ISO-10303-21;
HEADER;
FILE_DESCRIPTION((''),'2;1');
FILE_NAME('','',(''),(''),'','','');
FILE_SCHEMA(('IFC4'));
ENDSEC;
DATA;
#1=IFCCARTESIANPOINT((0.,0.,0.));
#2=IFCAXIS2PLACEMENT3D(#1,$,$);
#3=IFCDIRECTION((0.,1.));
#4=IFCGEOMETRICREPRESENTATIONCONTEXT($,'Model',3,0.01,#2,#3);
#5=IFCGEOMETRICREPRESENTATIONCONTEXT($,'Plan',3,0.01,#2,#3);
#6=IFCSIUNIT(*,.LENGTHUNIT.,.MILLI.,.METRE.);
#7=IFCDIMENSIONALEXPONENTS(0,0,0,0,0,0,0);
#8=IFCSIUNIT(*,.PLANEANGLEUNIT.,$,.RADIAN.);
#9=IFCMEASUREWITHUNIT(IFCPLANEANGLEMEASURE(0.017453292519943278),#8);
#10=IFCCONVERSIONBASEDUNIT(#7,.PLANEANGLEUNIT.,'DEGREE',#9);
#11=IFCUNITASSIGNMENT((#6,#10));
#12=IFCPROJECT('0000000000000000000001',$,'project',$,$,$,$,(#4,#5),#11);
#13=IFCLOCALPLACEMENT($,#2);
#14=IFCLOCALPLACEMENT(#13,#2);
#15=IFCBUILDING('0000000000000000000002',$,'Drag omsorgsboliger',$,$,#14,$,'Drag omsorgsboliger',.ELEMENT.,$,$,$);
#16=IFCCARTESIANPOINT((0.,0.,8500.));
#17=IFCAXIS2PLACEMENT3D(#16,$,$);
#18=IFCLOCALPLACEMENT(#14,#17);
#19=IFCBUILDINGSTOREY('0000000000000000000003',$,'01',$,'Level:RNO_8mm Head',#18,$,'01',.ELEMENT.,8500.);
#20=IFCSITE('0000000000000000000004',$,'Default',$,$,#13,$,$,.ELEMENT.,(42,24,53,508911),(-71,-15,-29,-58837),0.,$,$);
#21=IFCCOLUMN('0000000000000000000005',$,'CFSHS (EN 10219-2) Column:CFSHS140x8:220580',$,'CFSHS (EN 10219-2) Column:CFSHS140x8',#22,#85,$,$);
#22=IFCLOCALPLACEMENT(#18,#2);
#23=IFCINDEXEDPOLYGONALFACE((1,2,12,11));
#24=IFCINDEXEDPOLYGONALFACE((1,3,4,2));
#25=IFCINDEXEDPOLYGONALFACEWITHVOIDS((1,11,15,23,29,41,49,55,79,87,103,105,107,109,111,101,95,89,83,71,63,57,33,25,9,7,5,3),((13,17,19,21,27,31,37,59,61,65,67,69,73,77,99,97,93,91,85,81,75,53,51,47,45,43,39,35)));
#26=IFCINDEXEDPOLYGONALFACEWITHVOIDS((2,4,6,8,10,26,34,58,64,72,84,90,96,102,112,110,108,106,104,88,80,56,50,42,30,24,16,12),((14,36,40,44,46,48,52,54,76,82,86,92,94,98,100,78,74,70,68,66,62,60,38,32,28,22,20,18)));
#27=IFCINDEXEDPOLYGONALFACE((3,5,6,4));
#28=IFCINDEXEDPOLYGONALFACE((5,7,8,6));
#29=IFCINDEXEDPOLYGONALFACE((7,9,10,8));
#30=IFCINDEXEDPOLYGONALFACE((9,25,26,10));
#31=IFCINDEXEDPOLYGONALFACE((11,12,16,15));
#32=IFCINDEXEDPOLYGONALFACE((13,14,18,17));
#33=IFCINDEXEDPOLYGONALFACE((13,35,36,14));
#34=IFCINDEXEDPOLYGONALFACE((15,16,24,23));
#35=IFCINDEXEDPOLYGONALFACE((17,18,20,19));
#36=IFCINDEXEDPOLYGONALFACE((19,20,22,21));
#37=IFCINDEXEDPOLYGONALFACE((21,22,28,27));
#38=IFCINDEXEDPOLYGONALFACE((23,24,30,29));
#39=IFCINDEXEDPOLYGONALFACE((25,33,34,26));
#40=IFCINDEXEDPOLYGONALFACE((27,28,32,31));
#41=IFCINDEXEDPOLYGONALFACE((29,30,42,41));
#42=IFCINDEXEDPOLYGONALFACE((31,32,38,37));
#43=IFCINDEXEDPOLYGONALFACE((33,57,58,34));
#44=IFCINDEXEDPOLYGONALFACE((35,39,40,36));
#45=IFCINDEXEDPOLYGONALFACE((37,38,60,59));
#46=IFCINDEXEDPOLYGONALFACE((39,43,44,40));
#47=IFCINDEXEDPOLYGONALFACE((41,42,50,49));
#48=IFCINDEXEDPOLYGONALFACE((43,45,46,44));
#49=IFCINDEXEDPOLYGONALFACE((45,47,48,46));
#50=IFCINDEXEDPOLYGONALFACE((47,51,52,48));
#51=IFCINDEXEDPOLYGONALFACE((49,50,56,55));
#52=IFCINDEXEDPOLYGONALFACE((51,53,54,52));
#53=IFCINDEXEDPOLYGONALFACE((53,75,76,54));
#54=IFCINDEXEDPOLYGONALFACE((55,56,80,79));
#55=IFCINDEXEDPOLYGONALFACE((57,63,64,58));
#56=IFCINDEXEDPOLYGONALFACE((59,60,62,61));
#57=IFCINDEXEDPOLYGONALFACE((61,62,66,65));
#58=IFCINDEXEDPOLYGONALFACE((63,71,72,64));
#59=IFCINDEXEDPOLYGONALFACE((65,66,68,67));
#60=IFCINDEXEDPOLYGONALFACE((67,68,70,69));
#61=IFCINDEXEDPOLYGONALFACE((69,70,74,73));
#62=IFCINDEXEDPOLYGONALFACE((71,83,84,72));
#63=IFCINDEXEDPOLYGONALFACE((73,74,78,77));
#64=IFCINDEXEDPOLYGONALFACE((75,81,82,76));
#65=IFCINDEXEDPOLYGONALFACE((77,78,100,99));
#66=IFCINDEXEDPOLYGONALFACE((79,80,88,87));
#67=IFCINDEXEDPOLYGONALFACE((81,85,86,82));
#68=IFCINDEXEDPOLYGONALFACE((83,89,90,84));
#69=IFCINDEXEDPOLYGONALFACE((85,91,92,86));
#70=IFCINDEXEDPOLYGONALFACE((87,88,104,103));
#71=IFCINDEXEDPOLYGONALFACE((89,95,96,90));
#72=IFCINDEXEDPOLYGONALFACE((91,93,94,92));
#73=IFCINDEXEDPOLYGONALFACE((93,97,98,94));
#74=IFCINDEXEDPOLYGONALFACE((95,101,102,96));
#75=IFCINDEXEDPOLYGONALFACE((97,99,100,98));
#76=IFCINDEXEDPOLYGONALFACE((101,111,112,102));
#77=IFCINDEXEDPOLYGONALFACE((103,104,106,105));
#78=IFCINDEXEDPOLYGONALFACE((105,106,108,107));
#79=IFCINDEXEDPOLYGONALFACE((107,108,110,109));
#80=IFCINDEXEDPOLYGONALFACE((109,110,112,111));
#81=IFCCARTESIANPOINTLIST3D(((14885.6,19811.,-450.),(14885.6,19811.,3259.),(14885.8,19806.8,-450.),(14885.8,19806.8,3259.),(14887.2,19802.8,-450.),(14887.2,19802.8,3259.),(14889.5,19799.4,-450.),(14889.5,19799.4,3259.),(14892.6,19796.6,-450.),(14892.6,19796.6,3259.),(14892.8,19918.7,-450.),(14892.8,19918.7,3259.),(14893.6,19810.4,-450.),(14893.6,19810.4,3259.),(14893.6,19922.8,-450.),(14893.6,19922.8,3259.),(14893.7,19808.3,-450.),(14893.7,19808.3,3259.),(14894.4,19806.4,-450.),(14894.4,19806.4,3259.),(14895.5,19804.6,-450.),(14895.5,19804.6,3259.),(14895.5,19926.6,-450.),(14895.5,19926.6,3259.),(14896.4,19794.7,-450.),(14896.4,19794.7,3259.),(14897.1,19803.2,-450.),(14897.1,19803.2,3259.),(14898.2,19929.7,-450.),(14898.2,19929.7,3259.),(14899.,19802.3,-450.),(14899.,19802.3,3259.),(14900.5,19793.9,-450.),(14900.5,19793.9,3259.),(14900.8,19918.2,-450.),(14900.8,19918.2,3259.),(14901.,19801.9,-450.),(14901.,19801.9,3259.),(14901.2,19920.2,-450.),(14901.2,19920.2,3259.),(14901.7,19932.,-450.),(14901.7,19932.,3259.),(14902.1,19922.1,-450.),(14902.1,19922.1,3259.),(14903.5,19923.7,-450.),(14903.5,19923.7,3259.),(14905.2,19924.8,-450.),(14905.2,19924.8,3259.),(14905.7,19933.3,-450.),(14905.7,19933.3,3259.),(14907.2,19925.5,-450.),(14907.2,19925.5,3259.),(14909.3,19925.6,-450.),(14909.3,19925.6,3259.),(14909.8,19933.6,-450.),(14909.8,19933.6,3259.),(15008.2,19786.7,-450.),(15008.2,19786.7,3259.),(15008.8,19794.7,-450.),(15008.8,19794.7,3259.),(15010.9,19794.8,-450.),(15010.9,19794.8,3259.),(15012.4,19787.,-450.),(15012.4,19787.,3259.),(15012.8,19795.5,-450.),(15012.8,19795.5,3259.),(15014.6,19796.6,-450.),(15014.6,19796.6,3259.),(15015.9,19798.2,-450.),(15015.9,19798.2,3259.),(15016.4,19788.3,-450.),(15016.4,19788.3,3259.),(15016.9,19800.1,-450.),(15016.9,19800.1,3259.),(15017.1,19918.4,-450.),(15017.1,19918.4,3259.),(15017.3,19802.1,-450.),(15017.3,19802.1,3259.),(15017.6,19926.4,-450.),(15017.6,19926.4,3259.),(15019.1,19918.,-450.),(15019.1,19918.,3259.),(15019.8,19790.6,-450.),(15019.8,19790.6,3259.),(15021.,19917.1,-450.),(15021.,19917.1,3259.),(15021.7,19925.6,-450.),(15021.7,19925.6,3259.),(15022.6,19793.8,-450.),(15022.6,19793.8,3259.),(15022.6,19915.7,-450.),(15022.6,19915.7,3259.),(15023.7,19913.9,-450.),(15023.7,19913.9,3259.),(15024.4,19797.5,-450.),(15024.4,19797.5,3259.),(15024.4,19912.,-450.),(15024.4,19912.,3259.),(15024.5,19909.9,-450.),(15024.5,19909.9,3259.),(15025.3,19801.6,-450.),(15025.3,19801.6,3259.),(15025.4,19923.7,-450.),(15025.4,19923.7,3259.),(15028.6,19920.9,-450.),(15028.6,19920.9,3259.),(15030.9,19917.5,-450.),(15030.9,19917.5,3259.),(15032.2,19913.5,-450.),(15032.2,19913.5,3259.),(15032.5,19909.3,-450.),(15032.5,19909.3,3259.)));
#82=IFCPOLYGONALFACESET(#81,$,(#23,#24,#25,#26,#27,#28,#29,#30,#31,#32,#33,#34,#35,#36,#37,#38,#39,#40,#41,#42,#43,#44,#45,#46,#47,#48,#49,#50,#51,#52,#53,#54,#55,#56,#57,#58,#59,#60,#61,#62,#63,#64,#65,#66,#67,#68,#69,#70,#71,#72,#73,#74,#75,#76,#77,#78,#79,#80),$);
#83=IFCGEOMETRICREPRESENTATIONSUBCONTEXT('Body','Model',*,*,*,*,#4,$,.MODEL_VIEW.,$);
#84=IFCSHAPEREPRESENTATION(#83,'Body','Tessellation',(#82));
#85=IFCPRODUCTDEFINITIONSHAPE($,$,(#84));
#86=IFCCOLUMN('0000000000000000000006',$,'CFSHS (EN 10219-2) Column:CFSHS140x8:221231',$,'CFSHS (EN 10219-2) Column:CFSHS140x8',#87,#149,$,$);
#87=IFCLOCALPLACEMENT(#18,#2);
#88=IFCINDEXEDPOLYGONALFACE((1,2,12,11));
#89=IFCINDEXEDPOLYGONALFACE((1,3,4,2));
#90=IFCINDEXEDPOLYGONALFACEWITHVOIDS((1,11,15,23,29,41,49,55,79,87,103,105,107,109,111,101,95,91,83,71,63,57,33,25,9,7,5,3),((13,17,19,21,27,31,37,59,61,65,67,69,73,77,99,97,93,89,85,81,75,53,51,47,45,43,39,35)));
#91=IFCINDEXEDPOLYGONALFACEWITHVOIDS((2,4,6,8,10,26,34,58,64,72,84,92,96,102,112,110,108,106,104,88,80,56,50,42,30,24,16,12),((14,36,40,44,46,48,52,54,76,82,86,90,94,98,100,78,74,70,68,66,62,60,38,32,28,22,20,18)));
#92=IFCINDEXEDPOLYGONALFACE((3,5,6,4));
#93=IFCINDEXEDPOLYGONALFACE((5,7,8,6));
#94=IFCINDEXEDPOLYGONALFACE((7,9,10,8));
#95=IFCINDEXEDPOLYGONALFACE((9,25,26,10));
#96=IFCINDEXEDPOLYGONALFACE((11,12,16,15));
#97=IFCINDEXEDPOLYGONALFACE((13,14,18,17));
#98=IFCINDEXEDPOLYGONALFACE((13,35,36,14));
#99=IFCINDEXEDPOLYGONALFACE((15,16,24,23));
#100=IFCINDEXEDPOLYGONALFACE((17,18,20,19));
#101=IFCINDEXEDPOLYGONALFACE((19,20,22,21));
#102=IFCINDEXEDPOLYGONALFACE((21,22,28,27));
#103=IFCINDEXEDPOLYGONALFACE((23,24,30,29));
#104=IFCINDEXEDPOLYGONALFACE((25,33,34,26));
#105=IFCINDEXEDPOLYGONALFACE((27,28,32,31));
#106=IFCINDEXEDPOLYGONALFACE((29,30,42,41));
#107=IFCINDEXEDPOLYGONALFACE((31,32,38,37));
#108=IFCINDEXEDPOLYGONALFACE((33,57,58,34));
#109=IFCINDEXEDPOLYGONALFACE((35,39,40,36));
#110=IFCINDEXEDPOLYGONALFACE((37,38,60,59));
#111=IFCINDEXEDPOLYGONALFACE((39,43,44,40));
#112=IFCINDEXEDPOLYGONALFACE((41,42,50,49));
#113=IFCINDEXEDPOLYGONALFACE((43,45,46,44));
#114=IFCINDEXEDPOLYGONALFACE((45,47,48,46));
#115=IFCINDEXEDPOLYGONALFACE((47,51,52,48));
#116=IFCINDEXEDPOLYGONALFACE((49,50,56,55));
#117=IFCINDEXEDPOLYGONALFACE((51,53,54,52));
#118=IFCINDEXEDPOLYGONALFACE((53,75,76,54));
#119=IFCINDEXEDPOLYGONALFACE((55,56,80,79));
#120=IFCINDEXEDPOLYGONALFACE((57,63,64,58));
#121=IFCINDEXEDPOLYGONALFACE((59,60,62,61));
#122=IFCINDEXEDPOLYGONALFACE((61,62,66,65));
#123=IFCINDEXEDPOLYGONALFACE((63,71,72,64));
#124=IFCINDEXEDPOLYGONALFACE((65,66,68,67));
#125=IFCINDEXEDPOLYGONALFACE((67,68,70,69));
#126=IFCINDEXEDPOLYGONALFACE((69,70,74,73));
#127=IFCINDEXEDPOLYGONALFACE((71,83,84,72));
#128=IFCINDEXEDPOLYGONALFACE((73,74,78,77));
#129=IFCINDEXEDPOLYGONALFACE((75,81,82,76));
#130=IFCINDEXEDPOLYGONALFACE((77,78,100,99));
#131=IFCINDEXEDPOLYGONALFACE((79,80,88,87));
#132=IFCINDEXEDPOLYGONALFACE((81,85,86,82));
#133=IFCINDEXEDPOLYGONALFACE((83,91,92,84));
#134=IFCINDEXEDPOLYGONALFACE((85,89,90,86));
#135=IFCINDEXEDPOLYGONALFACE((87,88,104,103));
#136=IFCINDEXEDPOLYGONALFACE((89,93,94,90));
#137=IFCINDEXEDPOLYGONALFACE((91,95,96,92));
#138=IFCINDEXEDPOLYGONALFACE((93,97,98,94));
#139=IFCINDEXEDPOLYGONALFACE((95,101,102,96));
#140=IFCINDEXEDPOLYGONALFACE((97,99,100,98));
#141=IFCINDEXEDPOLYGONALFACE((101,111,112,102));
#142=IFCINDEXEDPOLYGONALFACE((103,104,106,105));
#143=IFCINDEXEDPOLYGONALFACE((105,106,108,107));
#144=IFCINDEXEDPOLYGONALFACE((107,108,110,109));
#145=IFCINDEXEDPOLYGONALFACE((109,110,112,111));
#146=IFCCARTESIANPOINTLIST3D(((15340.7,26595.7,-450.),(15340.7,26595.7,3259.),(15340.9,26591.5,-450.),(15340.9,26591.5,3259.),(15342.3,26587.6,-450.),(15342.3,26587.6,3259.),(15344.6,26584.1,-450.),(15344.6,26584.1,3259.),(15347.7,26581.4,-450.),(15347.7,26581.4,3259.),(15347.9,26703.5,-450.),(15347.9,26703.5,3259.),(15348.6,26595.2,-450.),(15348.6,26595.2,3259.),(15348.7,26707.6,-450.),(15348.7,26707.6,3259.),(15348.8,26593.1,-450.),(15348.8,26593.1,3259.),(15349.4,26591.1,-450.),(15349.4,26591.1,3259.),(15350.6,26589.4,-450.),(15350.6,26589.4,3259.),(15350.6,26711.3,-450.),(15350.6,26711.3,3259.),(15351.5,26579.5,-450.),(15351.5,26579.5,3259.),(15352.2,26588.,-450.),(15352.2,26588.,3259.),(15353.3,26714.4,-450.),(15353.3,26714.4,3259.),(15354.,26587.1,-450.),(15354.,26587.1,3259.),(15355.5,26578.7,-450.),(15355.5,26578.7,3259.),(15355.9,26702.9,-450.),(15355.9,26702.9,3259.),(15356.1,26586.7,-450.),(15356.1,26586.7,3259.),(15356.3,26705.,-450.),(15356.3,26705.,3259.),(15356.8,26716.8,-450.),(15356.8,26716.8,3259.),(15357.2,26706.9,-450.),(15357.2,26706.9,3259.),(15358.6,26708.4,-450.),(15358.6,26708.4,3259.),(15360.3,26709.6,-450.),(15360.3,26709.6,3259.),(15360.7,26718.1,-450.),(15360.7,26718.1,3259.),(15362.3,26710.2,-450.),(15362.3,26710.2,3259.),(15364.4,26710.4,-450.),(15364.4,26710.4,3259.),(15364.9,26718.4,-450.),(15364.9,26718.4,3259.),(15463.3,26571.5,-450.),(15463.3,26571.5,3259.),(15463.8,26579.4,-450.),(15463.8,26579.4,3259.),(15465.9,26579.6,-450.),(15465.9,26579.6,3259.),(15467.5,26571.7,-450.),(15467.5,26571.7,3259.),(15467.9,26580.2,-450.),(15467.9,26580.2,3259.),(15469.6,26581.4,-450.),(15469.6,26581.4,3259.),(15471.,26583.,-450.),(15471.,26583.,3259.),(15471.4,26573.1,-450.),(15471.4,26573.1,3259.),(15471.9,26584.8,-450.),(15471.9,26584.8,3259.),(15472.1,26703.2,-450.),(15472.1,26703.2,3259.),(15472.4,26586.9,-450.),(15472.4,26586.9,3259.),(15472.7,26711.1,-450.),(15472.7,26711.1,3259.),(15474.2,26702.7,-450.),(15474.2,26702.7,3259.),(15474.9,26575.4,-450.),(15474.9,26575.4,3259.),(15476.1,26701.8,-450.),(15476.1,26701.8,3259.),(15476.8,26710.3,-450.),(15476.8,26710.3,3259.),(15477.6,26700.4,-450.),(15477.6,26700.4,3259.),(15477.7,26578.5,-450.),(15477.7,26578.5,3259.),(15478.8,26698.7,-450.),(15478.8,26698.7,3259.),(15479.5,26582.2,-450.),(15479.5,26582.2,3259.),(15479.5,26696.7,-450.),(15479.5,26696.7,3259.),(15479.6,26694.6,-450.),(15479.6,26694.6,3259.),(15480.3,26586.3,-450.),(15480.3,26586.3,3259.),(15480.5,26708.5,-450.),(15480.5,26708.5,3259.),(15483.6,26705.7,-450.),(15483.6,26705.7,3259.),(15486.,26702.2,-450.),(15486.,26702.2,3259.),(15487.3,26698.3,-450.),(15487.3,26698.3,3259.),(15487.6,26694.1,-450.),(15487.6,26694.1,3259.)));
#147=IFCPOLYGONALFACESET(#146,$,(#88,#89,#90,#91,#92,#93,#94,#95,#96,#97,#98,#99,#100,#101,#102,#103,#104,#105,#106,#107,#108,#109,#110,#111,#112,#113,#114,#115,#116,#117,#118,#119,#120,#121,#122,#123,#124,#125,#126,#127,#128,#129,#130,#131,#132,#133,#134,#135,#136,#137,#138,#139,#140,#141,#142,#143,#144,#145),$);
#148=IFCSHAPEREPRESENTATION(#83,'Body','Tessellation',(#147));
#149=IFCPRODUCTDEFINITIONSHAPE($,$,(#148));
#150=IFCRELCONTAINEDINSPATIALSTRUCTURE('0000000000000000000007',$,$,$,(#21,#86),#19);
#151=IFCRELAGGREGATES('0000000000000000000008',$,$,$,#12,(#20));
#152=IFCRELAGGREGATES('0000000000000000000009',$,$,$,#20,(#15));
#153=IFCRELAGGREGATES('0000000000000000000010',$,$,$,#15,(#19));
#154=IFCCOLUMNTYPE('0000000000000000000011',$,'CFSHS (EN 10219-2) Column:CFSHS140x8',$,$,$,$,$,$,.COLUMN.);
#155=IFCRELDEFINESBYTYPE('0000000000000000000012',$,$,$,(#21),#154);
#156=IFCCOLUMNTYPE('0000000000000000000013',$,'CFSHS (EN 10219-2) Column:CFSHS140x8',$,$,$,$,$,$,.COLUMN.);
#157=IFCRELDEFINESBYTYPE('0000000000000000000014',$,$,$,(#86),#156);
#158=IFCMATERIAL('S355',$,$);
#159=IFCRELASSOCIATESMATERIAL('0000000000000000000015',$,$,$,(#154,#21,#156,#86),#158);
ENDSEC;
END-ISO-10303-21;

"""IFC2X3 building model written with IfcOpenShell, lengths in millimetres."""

from ifc_helpers import new_model, entity, si_unit, converted_unit, direction, frame, frame_2d, origin, place, context, subcontext, project, spatial, polyline, circle_curve, parameter, trimmed, segment, composite_curve, outline, extrude, source, transform, mapped, material, type_object, type_shapes, element, save


model = new_model("IFC2X3")

# Units and contexts
model_context = context("Model", 3, precision=0.01, world=origin(), true_north=direction((0.0, 1.0)))
plan_context = context("Plan", 3, precision=0.01, world=origin(), true_north=direction((0.0, 1.0)))
body_context = subcontext(model_context, "Body", "Model", "MODEL_VIEW")
ifc_project = project(units=[si_unit("LENGTHUNIT", "METRE", prefix="MILLI"), converted_unit("PLANEANGLEUNIT", "DEGREE", entity("IfcPlaneAngleMeasure", 0.017453292519943278), si_unit("PLANEANGLEUNIT", "RADIAN"), dimensions=[0, 0, 0, 0, 0, 0, 0])], contexts=[model_context, plan_context])

# Site, building, storey
site_placement = place(None, origin())
site = spatial("IfcSite", under=ifc_project, at=site_placement, Name="Default", CompositionType="ELEMENT", RefLatitude=(42, 24, 53, 508911), RefLongitude=(-71, -15, -29, -58837), RefElevation=0.0)
building_placement = place(site_placement, origin())
building = spatial("IfcBuilding", under=site, at=building_placement, Name="Drag omsorgsboliger", LongName="Drag omsorgsboliger", CompositionType="ELEMENT")
storey_placement = place(building_placement, frame((0.0, 0.0, 8500.0)))
storey = spatial("IfcBuildingStorey", under=building, at=storey_placement, Name="01", ObjectType="Level:RNO_8mm Head", LongName="01", CompositionType="ELEMENT", Elevation=8500.0)

# Columns
ifc_material = material(Name="S355")
column_type_1 = type_object("IfcColumnType", Name="CFSHS (EN 10219-2) Column:CFSHS140x8", PredefinedType="COLUMN", material=ifc_material)
shared_shape_1 = source(origin(), body_context, "Body", "SweptSolid", [
    extrude(outline(composite_curve([segment(polyline([(-54.0, -70.0), (54.0, -70.0)]), True, "CONTINUOUS"), segment(trimmed(circle_curve(frame_2d((54.0, -54.0), x_axis=(-1.0, 0.0)), 16.0), [parameter(90.0)], [parameter(180.0)], True, "PARAMETER"), True, "CONTINUOUS"), segment(polyline([(70.0, -54.0), (70.0, 54.0)]), True, "CONTINUOUS"), segment(trimmed(circle_curve(frame_2d((54.0, 54.0), x_axis=(-1.0, 0.0)), 16.0), [parameter(180.0)], [parameter(270.0)], True, "PARAMETER"), True, "CONTINUOUS"), segment(polyline([(54.0, 70.0), (-54.0, 70.0)]), True, "CONTINUOUS"), segment(trimmed(circle_curve(frame_2d((-54.0, 54.0), x_axis=(-1.0, 0.0)), 16.0), [parameter(270.0)], [parameter(360.0)], True, "PARAMETER"), True, "CONTINUOUS"), segment(polyline([(-70.0, 54.0), (-70.0, -54.0)]), True, "CONTINUOUS"), segment(trimmed(circle_curve(frame_2d((-54.0, -54.0), x_axis=(-1.0, 0.0)), 16.0), [parameter(360.0)], [parameter(90.0)], True, "PARAMETER"), True, "CONTINUOUS")], self_intersect=False), holes=[composite_curve([segment(trimmed(circle_curve(frame_2d((-54.0, -54.0), x_axis=(-1.0, 0.0)), 8.0), [parameter(360.0)], [parameter(90.0)], True, "PARAMETER"), False, "CONTINUOUS"), segment(polyline([(-62.0, -54.0), (-62.0, 54.0)]), True, "CONTINUOUS"), segment(trimmed(circle_curve(frame_2d((-54.0, 54.0), x_axis=(-1.0, 0.0)), 8.0), [parameter(270.0)], [parameter(360.0)], True, "PARAMETER"), False, "CONTINUOUS"), segment(polyline([(-54.0, 62.0), (54.0, 62.0)]), True, "CONTINUOUS"), segment(trimmed(circle_curve(frame_2d((54.0, 54.0), x_axis=(-1.0, 0.0)), 8.0), [parameter(180.0)], [parameter(270.0)], True, "PARAMETER"), False, "CONTINUOUS"), segment(polyline([(62.0, 54.0), (62.0, -54.0)]), True, "CONTINUOUS"), segment(trimmed(circle_curve(frame_2d((54.0, -54.0), x_axis=(-1.0, 0.0)), 8.0), [parameter(90.0)], [parameter(180.0)], True, "PARAMETER"), False, "CONTINUOUS"), segment(polyline([(54.0, -62.0), (-54.0, -62.0)]), True, "CONTINUOUS")], self_intersect=False)]), frame((14959.0, 19860.2, 8050.0), z_axis=(0.0, 0.0, 1.0), x_axis=(-0.997758, 0.066923, 0.0)), (0.0, 0.0, 1.0), 3709.0),
])
type_shapes(column_type_1, [shared_shape_1])
column_1_placement = place(storey_placement, frame((0.0, 0.0, -8500.0)))
element("IfcColumn", 1, at=column_1_placement, inside=storey, type_object=column_type_1, material=ifc_material, Name="CFSHS (EN 10219-2) Column:CFSHS140x8:220580", ObjectType="CFSHS (EN 10219-2) Column:CFSHS140x8", context=body_context, shape_type="MappedRepresentation", body=[
    mapped(shared_shape_1, transform((0.0, 0.0, 0.0), scale=1.0)),
])
column_type_2 = type_object("IfcColumnType", Name="CFSHS (EN 10219-2) Column:CFSHS140x8", PredefinedType="COLUMN", material=ifc_material)
shared_shape_2 = source(origin(), body_context, "Body", "SweptSolid", [
    extrude(outline(composite_curve([segment(polyline([(-54.0, -70.0), (54.0, -70.0)]), True, "CONTINUOUS"), segment(trimmed(circle_curve(frame_2d((54.0, -54.0), x_axis=(-1.0, 0.0)), 16.0), [parameter(90.0)], [parameter(180.0)], True, "PARAMETER"), True, "CONTINUOUS"), segment(polyline([(70.0, -54.0), (70.0, 54.0)]), True, "CONTINUOUS"), segment(trimmed(circle_curve(frame_2d((54.0, 54.0), x_axis=(-1.0, 0.0)), 16.0), [parameter(180.0)], [parameter(270.0)], True, "PARAMETER"), True, "CONTINUOUS"), segment(polyline([(54.0, 70.0), (-54.0, 70.0)]), True, "CONTINUOUS"), segment(trimmed(circle_curve(frame_2d((-54.0, 54.0), x_axis=(-1.0, 0.0)), 16.0), [parameter(270.0)], [parameter(360.0)], True, "PARAMETER"), True, "CONTINUOUS"), segment(polyline([(-70.0, 54.0), (-70.0, -54.0)]), True, "CONTINUOUS"), segment(trimmed(circle_curve(frame_2d((-54.0, -54.0), x_axis=(-1.0, 0.0)), 16.0), [parameter(360.0)], [parameter(90.0)], True, "PARAMETER"), True, "CONTINUOUS")], self_intersect=False), holes=[composite_curve([segment(trimmed(circle_curve(frame_2d((-54.0, -54.0), x_axis=(-1.0, 0.0)), 8.0), [parameter(360.0)], [parameter(90.0)], True, "PARAMETER"), False, "CONTINUOUS"), segment(polyline([(-62.0, -54.0), (-62.0, 54.0)]), True, "CONTINUOUS"), segment(trimmed(circle_curve(frame_2d((-54.0, 54.0), x_axis=(-1.0, 0.0)), 8.0), [parameter(270.0)], [parameter(360.0)], True, "PARAMETER"), False, "CONTINUOUS"), segment(polyline([(-54.0, 62.0), (54.0, 62.0)]), True, "CONTINUOUS"), segment(trimmed(circle_curve(frame_2d((54.0, 54.0), x_axis=(-1.0, 0.0)), 8.0), [parameter(180.0)], [parameter(270.0)], True, "PARAMETER"), False, "CONTINUOUS"), segment(polyline([(62.0, 54.0), (62.0, -54.0)]), True, "CONTINUOUS"), segment(trimmed(circle_curve(frame_2d((54.0, -54.0), x_axis=(-1.0, 0.0)), 8.0), [parameter(90.0)], [parameter(180.0)], True, "PARAMETER"), False, "CONTINUOUS"), segment(polyline([(54.0, -62.0), (-54.0, -62.0)]), True, "CONTINUOUS")], self_intersect=False)]), frame((15414.1, 26644.9, 8050.0), z_axis=(0.0, 0.0, 1.0), x_axis=(-0.997758, 0.066923, 0.0)), (0.0, 0.0, 1.0), 3709.0),
])
type_shapes(column_type_2, [shared_shape_2])
column_2_placement = place(storey_placement, frame((0.0, 0.0, -8500.0)))
element("IfcColumn", 2, at=column_2_placement, inside=storey, type_object=column_type_2, material=ifc_material, Name="CFSHS (EN 10219-2) Column:CFSHS140x8:221231", ObjectType="CFSHS (EN 10219-2) Column:CFSHS140x8", context=body_context, shape_type="MappedRepresentation", body=[
    mapped(shared_shape_2, transform((0.0, 0.0, 0.0), scale=1.0)),
])

save(model, "model.ifc")
